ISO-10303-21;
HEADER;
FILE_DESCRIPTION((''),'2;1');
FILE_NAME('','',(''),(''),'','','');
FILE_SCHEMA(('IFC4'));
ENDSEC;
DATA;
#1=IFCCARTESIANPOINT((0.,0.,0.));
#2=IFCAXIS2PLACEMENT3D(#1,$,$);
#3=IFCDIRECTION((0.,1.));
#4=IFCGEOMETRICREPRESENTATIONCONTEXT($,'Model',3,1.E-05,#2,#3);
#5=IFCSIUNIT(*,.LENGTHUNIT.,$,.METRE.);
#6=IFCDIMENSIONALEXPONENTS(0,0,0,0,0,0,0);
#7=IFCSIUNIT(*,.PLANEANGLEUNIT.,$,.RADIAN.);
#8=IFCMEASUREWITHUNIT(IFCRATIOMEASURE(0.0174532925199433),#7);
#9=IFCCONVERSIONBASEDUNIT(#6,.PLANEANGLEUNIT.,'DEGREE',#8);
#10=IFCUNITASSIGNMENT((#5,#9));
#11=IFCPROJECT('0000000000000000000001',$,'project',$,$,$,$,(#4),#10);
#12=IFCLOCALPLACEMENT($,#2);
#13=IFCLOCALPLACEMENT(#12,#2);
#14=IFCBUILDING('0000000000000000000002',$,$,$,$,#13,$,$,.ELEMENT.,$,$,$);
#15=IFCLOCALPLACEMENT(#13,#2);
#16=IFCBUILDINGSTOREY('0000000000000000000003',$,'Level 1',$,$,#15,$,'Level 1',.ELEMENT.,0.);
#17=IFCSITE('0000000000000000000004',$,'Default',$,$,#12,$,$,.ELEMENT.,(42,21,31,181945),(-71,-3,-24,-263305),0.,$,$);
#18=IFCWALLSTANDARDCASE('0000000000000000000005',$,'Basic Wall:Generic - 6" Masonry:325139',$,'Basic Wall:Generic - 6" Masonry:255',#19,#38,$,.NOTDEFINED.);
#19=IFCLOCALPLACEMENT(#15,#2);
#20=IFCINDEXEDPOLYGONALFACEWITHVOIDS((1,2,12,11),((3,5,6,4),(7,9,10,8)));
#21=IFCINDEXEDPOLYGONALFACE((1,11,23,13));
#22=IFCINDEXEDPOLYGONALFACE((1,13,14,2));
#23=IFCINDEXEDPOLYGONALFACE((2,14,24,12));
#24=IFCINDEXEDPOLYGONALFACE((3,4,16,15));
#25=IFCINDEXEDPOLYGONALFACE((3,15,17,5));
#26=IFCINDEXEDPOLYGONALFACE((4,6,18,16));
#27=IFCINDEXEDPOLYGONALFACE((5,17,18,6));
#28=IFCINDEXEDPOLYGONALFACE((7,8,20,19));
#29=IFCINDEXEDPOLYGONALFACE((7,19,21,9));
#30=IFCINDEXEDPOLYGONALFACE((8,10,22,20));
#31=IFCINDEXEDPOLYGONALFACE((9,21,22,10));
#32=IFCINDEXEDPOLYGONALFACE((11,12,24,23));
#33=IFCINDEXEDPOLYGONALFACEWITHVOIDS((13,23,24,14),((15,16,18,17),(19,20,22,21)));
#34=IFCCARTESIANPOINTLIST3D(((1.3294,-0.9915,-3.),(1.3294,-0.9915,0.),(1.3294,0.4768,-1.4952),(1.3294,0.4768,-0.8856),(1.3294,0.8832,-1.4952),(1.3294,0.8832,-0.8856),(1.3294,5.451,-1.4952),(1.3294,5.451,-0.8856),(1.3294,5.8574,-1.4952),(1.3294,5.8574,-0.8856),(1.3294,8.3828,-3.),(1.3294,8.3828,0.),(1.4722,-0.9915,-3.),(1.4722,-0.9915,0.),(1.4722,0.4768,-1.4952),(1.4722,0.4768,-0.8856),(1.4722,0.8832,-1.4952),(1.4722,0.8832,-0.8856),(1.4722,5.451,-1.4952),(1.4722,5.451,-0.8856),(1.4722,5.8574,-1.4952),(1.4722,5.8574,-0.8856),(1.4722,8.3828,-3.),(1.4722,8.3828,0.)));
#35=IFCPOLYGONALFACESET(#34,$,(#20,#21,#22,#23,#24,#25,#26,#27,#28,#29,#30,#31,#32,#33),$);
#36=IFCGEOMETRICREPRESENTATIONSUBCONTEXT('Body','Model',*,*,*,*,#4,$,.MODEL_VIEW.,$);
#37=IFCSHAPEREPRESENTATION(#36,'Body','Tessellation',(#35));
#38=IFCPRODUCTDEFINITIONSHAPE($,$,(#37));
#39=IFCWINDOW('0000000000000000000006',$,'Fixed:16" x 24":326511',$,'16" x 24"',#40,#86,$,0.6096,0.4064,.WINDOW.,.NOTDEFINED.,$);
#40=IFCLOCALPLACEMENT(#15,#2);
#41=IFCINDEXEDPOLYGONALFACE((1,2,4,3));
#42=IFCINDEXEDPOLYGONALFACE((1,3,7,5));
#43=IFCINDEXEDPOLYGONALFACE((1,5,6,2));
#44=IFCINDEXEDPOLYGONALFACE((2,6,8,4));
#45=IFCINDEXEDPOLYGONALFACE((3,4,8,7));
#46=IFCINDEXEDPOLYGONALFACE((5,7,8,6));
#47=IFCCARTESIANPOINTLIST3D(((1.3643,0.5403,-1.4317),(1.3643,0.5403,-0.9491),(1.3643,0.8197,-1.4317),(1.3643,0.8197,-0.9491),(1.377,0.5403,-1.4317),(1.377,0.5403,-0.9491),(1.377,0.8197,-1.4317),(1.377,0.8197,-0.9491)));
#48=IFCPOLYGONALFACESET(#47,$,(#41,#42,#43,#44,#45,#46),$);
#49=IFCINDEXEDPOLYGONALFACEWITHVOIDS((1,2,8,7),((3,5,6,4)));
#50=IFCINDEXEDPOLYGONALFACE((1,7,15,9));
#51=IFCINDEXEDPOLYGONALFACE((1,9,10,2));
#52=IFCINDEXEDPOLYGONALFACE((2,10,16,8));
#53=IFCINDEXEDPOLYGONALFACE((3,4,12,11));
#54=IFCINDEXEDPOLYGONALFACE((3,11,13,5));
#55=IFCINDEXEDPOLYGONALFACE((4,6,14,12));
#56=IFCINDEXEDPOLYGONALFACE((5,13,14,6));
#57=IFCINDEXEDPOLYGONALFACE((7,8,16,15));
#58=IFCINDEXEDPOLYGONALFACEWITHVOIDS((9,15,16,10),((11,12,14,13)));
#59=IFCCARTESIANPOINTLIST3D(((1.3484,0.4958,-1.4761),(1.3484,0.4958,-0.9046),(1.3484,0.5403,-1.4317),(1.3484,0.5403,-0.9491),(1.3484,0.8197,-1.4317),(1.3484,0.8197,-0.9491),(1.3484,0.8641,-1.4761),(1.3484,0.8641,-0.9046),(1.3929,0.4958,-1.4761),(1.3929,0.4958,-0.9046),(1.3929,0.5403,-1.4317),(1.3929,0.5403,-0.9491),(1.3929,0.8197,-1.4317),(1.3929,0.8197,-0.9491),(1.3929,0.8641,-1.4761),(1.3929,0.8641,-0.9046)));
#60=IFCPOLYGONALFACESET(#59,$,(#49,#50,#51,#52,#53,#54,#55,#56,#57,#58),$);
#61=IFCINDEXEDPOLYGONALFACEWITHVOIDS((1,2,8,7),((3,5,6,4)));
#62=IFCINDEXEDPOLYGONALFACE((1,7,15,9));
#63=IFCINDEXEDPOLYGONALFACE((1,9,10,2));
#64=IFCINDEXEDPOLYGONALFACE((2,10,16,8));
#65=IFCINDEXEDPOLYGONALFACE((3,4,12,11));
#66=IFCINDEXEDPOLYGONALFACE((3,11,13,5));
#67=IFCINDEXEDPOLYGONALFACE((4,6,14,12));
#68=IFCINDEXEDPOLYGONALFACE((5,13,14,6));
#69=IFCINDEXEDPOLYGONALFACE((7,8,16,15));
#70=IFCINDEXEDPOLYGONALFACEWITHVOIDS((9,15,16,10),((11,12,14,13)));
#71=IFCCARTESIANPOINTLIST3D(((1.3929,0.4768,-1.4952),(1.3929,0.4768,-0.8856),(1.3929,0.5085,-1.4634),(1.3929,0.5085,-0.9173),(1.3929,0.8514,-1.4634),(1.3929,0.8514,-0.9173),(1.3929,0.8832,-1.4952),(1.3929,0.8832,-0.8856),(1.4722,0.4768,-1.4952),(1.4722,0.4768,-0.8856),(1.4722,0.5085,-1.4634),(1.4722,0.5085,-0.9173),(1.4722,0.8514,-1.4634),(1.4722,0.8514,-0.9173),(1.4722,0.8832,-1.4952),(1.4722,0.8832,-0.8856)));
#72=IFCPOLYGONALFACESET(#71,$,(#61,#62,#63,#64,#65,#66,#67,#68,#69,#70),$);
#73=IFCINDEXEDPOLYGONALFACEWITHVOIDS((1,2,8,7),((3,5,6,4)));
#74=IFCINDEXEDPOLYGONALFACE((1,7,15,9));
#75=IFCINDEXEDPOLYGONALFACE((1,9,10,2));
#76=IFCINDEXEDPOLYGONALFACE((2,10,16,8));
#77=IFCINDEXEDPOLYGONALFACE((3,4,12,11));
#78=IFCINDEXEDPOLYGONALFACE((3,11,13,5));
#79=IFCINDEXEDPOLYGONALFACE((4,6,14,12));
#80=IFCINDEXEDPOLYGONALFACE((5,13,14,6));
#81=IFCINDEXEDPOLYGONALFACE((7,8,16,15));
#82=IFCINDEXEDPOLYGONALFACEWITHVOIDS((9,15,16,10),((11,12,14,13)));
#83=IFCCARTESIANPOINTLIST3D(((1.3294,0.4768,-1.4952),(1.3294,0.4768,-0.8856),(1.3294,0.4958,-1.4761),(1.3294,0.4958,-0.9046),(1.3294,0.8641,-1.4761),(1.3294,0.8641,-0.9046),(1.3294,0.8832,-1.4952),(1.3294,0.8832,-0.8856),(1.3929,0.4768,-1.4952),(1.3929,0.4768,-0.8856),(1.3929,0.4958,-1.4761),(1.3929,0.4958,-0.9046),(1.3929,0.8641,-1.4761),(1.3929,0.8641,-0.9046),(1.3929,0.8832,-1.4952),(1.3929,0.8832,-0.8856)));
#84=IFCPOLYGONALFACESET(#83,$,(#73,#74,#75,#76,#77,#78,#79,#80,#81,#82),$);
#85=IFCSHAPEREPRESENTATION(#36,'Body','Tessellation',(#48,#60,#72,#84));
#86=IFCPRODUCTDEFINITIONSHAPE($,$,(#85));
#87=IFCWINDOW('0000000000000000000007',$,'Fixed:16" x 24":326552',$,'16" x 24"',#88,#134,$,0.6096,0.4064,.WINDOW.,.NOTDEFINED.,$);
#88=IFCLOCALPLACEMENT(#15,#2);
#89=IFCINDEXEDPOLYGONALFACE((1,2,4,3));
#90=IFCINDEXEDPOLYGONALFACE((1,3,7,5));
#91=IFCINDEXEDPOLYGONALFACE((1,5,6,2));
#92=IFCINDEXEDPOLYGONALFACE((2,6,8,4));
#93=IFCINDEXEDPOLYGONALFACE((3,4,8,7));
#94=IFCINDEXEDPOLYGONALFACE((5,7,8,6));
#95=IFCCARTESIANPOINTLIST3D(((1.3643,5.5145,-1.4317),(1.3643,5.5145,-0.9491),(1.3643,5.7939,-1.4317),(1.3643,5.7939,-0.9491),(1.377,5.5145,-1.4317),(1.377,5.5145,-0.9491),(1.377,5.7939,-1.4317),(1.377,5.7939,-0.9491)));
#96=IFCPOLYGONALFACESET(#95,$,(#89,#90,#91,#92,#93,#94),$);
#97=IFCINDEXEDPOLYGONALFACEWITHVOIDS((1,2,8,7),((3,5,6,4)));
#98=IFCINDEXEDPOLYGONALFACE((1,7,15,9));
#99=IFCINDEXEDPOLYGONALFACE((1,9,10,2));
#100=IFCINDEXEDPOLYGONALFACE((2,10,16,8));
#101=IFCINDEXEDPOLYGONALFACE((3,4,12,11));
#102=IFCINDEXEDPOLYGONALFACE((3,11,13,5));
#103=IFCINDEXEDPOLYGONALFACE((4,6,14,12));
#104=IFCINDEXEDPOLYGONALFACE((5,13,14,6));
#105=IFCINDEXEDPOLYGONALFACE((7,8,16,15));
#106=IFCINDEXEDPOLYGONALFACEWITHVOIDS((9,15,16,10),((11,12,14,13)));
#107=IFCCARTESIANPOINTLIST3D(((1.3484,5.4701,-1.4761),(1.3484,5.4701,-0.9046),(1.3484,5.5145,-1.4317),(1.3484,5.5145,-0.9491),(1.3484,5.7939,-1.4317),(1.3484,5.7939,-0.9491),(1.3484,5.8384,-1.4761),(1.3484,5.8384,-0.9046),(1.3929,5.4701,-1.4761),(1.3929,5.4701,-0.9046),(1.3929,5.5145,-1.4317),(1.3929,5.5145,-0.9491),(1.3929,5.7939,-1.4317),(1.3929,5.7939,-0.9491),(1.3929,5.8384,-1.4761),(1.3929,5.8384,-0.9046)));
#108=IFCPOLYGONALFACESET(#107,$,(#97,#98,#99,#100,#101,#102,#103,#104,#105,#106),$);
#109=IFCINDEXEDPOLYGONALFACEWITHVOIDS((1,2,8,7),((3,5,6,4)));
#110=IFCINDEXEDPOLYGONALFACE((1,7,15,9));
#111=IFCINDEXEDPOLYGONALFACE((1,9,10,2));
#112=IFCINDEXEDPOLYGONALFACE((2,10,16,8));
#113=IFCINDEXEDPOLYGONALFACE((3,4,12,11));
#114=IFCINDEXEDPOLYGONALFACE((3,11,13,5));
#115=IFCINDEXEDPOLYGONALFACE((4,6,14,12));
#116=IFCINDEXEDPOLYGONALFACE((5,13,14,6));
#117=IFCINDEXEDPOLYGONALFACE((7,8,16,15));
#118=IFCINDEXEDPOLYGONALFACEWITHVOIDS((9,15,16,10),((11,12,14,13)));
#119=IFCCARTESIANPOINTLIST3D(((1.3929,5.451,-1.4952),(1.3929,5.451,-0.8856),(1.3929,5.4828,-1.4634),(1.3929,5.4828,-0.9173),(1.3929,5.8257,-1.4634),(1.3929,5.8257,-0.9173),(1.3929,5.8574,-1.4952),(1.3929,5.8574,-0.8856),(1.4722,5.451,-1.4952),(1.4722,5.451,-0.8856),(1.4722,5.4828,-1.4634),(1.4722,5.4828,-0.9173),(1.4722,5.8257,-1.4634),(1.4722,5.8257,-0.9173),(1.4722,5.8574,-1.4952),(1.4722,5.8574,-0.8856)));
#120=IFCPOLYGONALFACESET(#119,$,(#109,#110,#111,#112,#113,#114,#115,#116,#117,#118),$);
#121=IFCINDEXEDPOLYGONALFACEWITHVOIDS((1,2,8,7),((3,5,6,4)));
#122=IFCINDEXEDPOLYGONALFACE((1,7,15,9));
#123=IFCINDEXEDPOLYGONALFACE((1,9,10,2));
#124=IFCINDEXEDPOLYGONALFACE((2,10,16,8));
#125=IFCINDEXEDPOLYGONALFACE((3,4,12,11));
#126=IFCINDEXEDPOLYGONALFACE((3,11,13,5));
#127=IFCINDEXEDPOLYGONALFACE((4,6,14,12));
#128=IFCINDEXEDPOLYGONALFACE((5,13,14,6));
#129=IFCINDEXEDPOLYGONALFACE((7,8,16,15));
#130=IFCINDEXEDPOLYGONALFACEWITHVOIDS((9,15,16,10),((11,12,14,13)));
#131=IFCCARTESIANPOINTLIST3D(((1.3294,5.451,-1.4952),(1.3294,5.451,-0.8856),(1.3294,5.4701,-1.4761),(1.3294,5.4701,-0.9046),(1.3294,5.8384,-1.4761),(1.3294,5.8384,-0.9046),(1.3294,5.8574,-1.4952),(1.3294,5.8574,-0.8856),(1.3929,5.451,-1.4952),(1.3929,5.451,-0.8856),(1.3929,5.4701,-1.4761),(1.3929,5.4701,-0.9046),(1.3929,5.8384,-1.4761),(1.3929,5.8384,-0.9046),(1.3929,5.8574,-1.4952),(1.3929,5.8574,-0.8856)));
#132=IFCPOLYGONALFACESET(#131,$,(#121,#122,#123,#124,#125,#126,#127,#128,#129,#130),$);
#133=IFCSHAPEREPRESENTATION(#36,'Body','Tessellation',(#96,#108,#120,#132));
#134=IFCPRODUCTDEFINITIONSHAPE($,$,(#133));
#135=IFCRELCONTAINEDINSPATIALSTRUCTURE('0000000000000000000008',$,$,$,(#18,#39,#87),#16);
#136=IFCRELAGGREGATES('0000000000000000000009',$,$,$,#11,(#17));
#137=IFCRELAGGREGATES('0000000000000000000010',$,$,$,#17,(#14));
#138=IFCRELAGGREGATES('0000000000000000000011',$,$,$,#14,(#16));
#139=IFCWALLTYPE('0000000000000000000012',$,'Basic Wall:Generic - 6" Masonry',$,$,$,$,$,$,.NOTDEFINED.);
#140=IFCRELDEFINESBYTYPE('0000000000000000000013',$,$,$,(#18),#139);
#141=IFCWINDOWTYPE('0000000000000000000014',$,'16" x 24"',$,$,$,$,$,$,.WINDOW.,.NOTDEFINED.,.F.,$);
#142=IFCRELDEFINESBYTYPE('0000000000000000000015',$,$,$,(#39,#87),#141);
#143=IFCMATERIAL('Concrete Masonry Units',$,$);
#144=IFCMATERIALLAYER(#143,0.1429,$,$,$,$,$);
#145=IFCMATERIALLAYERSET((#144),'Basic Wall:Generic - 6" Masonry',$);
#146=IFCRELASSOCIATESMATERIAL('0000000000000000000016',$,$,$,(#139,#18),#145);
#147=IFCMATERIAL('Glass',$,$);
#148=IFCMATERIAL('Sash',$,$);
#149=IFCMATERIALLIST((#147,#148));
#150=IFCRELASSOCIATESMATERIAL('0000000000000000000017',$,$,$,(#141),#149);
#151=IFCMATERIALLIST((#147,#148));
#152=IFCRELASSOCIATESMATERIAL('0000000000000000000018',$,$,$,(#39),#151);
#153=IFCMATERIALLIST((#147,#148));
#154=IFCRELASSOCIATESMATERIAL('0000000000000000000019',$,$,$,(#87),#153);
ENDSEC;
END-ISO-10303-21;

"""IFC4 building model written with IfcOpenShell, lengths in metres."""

from ifc_helpers import new_model, entity, si_unit, converted_unit, direction, frame, frame_2d, origin, place, context, subcontext, project, spatial, polyline, rectangle, outline, extrude, source, transform, mapped, material, material_list, layer, layer_set, layer_usage, type_object, type_shapes, element, fill, save


model = new_model("IFC4")

# Units and contexts
model_context = context("Model", 3, precision=1e-05, world=origin(), true_north=direction((0.0, 1.0)))
body_context = subcontext(model_context, "Body", "Model", "MODEL_VIEW")
ifc_project = project(units=[si_unit("LENGTHUNIT", "METRE"), converted_unit("PLANEANGLEUNIT", "DEGREE", entity("IfcRatioMeasure", 0.0174532925199433), si_unit("PLANEANGLEUNIT", "RADIAN"), dimensions=[0, 0, 0, 0, 0, 0, 0])], contexts=[model_context])

# Site, building, storey
site_placement = place(None, origin())
site = spatial("IfcSite", under=ifc_project, at=site_placement, Name="Default", CompositionType="ELEMENT", RefLatitude=(42, 21, 31, 181945), RefLongitude=(-71, -3, -24, -263305), RefElevation=0.0)
building_placement = place(site_placement, origin())
building = spatial("IfcBuilding", under=site, at=building_placement, CompositionType="ELEMENT")
storey_placement = place(building_placement, origin())
storey = spatial("IfcBuildingStorey", under=building, at=storey_placement, Name="Level 1", LongName="Level 1", CompositionType="ELEMENT", Elevation=0.0)

# Wall, openings, windows
ifc_material_1 = material(Name="Concrete Masonry Units")
ifc_layer = layer(ifc_material_1, 0.1429)
ifc_layer_set = layer_set([ifc_layer], Name="Basic Wall:Generic - 6\" Masonry")
wall_type = type_object("IfcWallType", Name="Basic Wall:Generic - 6\" Masonry", PredefinedType="NOTDEFINED", material=ifc_layer_set)
ifc_material_2 = material(Name="Glass")
ifc_material_3 = material(Name="Sash")
ifc_material_list_1 = material_list([ifc_material_2, ifc_material_3])
window_type = type_object("IfcWindowType", Name="16\" x 24\"", ParameterTakesPrecedence=False, PartitioningType="NOTDEFINED", PredefinedType="WINDOW", material=ifc_material_list_1)
shared_shape = source(origin(), body_context, "Body", "SweptSolid", [
    extrude(rectangle(XDim=0.0127, YDim=0.2794, at=frame_2d((0.0, 0.0), x_axis=(1.0, 0.0))), frame((0.2032, 0.1016, 0.0635), z_axis=(0.0, 0.0, 1.0), x_axis=(0.0, 1.0, 0.0)), (0.0, 0.0, 1.0), 0.4826),
    extrude(outline(polyline([(-0.1841, -0.2858), (0.1841, -0.2858), (0.1841, 0.2858), (-0.1841, 0.2858), (-0.1841, -0.2858)]), holes=[polyline([(-0.1397, -0.2413), (-0.1397, 0.2413), (0.1397, 0.2413), (0.1397, -0.2413), (-0.1397, -0.2413)])]), frame((0.2032, 0.0794, 0.3048), z_axis=(0.0, 1.0, 0.0), x_axis=(1.0, 0.0, 0.0)), (0.0, 0.0, 1.0), 0.0445),
    extrude(outline(polyline([(-0.2032, -0.3048), (0.2032, -0.3048), (0.2032, 0.3048), (-0.2032, 0.3048), (-0.2032, -0.3048)]), holes=[polyline([(-0.1715, -0.273), (-0.1715, 0.2731), (0.1714, 0.2731), (0.1714, -0.273), (-0.1715, -0.273)])]), frame((0.2032, 0.0, 0.3048), z_axis=(0.0, 1.0, 0.0), x_axis=(1.0, 0.0, 0.0)), (0.0, 0.0, 1.0), 0.0794),
    extrude(outline(polyline([(-0.3048, -0.2032), (0.3048, -0.2032), (0.3048, 0.2032), (-0.3048, 0.2032), (-0.3048, -0.2032)]), holes=[polyline([(-0.2857, -0.1841), (-0.2857, 0.1842), (0.2858, 0.1842), (0.2858, -0.1841), (-0.2857, -0.1841)])]), frame((0.2032, 0.0794, 0.3048), z_axis=(0.0, 1.0, 0.0), x_axis=(0.0, 0.0, -1.0)), (0.0, 0.0, 1.0), 0.0635),
])
type_shapes(window_type, [shared_shape])
ifc_layer_usage_1 = layer_usage(ifc_layer_set, "AXIS2", "NEGATIVE", 0.0714)
wall_1_placement = place(storey_placement, frame((1.4008, 8.3828, -3.0), z_axis=(0.0, 0.0, 1.0), x_axis=(0.0, -1.0, 0.0)))
wall_1 = element("IfcWallStandardCase", 1, at=wall_1_placement, inside=storey, type_object=wall_type, material=ifc_layer_usage_1, Name="Basic Wall:Generic - 6\" Masonry:325139", ObjectType="Basic Wall:Generic - 6\" Masonry:255", PredefinedType="NOTDEFINED", context=body_context, shape_type="SweptSolid", body=[
    extrude(rectangle(XDim=9.3743, YDim=0.1429, at=frame_2d((4.6871, 0.0), x_axis=(-1.0, 0.0))), origin(), (0.0, 0.0, 1.0), 3.0),
])
opening_1_placement = place(wall_1_placement, frame((7.906, 0.0714, 1.5048)))
opening_1 = element("IfcOpeningElement", 2, at=opening_1_placement, cuts=wall_1, ObjectType="Opening", PredefinedType="OPENING", context=body_context, shape_type="SweptSolid", body=[
    extrude(rectangle(XDim=0.6096, YDim=0.4064, at=frame_2d((0.3048, 0.2032), x_axis=(-1.0, 0.0))), frame((0.0, 0.0, 0.0), z_axis=(0.0, -1.0, 0.0), x_axis=(0.0, 0.0, 1.0)), (0.0, 0.0, 1.0), 0.1429),
])
opening_2_placement = place(wall_1_placement, frame((2.9318, 0.0714, 1.5048)))
opening_2 = element("IfcOpeningElement", 3, at=opening_2_placement, cuts=wall_1, ObjectType="Opening", PredefinedType="OPENING", context=body_context, shape_type="SweptSolid", body=[
    extrude(rectangle(XDim=0.6096, YDim=0.4064, at=frame_2d((0.3048, 0.2032), x_axis=(-1.0, 0.0))), frame((0.0, 0.0, 0.0), z_axis=(0.0, -1.0, 0.0), x_axis=(0.0, 0.0, 1.0)), (0.0, 0.0, 1.0), 0.1429),
])
ifc_material_list_2 = material_list([ifc_material_2, ifc_material_3])
window_1_placement = place(opening_1_placement, frame((0.0, 0.0, 0.0), z_axis=(0.0, 0.0, 1.0), x_axis=(-1.0, 0.0, 0.0)))
window_1 = element("IfcWindow", 4, at=window_1_placement, inside=storey, type_object=window_type, material=ifc_material_list_2, Name="Fixed:16\" x 24\":326511", ObjectType="16\" x 24\"", OverallHeight=0.6096, OverallWidth=0.4064, PartitioningType="NOTDEFINED", PredefinedType="WINDOW", context=body_context, shape_type="MappedRepresentation", body=[
    mapped(shared_shape, transform((0.0, 0.0, 0.0), scale=1.0)),
])
fill(opening_1, window_1)
ifc_material_list_3 = material_list([ifc_material_2, ifc_material_3])
window_2_placement = place(opening_2_placement, frame((0.0, 0.0, 0.0), z_axis=(0.0, 0.0, 1.0), x_axis=(-1.0, 0.0, 0.0)))
window_2 = element("IfcWindow", 5, at=window_2_placement, inside=storey, type_object=window_type, material=ifc_material_list_3, Name="Fixed:16\" x 24\":326552", ObjectType="16\" x 24\"", OverallHeight=0.6096, OverallWidth=0.4064, PartitioningType="NOTDEFINED", PredefinedType="WINDOW", context=body_context, shape_type="MappedRepresentation", body=[
    mapped(shared_shape, transform((0.0, 0.0, 0.0), scale=1.0)),
])
fill(opening_2, window_2)

save(model, "model.ifc")
